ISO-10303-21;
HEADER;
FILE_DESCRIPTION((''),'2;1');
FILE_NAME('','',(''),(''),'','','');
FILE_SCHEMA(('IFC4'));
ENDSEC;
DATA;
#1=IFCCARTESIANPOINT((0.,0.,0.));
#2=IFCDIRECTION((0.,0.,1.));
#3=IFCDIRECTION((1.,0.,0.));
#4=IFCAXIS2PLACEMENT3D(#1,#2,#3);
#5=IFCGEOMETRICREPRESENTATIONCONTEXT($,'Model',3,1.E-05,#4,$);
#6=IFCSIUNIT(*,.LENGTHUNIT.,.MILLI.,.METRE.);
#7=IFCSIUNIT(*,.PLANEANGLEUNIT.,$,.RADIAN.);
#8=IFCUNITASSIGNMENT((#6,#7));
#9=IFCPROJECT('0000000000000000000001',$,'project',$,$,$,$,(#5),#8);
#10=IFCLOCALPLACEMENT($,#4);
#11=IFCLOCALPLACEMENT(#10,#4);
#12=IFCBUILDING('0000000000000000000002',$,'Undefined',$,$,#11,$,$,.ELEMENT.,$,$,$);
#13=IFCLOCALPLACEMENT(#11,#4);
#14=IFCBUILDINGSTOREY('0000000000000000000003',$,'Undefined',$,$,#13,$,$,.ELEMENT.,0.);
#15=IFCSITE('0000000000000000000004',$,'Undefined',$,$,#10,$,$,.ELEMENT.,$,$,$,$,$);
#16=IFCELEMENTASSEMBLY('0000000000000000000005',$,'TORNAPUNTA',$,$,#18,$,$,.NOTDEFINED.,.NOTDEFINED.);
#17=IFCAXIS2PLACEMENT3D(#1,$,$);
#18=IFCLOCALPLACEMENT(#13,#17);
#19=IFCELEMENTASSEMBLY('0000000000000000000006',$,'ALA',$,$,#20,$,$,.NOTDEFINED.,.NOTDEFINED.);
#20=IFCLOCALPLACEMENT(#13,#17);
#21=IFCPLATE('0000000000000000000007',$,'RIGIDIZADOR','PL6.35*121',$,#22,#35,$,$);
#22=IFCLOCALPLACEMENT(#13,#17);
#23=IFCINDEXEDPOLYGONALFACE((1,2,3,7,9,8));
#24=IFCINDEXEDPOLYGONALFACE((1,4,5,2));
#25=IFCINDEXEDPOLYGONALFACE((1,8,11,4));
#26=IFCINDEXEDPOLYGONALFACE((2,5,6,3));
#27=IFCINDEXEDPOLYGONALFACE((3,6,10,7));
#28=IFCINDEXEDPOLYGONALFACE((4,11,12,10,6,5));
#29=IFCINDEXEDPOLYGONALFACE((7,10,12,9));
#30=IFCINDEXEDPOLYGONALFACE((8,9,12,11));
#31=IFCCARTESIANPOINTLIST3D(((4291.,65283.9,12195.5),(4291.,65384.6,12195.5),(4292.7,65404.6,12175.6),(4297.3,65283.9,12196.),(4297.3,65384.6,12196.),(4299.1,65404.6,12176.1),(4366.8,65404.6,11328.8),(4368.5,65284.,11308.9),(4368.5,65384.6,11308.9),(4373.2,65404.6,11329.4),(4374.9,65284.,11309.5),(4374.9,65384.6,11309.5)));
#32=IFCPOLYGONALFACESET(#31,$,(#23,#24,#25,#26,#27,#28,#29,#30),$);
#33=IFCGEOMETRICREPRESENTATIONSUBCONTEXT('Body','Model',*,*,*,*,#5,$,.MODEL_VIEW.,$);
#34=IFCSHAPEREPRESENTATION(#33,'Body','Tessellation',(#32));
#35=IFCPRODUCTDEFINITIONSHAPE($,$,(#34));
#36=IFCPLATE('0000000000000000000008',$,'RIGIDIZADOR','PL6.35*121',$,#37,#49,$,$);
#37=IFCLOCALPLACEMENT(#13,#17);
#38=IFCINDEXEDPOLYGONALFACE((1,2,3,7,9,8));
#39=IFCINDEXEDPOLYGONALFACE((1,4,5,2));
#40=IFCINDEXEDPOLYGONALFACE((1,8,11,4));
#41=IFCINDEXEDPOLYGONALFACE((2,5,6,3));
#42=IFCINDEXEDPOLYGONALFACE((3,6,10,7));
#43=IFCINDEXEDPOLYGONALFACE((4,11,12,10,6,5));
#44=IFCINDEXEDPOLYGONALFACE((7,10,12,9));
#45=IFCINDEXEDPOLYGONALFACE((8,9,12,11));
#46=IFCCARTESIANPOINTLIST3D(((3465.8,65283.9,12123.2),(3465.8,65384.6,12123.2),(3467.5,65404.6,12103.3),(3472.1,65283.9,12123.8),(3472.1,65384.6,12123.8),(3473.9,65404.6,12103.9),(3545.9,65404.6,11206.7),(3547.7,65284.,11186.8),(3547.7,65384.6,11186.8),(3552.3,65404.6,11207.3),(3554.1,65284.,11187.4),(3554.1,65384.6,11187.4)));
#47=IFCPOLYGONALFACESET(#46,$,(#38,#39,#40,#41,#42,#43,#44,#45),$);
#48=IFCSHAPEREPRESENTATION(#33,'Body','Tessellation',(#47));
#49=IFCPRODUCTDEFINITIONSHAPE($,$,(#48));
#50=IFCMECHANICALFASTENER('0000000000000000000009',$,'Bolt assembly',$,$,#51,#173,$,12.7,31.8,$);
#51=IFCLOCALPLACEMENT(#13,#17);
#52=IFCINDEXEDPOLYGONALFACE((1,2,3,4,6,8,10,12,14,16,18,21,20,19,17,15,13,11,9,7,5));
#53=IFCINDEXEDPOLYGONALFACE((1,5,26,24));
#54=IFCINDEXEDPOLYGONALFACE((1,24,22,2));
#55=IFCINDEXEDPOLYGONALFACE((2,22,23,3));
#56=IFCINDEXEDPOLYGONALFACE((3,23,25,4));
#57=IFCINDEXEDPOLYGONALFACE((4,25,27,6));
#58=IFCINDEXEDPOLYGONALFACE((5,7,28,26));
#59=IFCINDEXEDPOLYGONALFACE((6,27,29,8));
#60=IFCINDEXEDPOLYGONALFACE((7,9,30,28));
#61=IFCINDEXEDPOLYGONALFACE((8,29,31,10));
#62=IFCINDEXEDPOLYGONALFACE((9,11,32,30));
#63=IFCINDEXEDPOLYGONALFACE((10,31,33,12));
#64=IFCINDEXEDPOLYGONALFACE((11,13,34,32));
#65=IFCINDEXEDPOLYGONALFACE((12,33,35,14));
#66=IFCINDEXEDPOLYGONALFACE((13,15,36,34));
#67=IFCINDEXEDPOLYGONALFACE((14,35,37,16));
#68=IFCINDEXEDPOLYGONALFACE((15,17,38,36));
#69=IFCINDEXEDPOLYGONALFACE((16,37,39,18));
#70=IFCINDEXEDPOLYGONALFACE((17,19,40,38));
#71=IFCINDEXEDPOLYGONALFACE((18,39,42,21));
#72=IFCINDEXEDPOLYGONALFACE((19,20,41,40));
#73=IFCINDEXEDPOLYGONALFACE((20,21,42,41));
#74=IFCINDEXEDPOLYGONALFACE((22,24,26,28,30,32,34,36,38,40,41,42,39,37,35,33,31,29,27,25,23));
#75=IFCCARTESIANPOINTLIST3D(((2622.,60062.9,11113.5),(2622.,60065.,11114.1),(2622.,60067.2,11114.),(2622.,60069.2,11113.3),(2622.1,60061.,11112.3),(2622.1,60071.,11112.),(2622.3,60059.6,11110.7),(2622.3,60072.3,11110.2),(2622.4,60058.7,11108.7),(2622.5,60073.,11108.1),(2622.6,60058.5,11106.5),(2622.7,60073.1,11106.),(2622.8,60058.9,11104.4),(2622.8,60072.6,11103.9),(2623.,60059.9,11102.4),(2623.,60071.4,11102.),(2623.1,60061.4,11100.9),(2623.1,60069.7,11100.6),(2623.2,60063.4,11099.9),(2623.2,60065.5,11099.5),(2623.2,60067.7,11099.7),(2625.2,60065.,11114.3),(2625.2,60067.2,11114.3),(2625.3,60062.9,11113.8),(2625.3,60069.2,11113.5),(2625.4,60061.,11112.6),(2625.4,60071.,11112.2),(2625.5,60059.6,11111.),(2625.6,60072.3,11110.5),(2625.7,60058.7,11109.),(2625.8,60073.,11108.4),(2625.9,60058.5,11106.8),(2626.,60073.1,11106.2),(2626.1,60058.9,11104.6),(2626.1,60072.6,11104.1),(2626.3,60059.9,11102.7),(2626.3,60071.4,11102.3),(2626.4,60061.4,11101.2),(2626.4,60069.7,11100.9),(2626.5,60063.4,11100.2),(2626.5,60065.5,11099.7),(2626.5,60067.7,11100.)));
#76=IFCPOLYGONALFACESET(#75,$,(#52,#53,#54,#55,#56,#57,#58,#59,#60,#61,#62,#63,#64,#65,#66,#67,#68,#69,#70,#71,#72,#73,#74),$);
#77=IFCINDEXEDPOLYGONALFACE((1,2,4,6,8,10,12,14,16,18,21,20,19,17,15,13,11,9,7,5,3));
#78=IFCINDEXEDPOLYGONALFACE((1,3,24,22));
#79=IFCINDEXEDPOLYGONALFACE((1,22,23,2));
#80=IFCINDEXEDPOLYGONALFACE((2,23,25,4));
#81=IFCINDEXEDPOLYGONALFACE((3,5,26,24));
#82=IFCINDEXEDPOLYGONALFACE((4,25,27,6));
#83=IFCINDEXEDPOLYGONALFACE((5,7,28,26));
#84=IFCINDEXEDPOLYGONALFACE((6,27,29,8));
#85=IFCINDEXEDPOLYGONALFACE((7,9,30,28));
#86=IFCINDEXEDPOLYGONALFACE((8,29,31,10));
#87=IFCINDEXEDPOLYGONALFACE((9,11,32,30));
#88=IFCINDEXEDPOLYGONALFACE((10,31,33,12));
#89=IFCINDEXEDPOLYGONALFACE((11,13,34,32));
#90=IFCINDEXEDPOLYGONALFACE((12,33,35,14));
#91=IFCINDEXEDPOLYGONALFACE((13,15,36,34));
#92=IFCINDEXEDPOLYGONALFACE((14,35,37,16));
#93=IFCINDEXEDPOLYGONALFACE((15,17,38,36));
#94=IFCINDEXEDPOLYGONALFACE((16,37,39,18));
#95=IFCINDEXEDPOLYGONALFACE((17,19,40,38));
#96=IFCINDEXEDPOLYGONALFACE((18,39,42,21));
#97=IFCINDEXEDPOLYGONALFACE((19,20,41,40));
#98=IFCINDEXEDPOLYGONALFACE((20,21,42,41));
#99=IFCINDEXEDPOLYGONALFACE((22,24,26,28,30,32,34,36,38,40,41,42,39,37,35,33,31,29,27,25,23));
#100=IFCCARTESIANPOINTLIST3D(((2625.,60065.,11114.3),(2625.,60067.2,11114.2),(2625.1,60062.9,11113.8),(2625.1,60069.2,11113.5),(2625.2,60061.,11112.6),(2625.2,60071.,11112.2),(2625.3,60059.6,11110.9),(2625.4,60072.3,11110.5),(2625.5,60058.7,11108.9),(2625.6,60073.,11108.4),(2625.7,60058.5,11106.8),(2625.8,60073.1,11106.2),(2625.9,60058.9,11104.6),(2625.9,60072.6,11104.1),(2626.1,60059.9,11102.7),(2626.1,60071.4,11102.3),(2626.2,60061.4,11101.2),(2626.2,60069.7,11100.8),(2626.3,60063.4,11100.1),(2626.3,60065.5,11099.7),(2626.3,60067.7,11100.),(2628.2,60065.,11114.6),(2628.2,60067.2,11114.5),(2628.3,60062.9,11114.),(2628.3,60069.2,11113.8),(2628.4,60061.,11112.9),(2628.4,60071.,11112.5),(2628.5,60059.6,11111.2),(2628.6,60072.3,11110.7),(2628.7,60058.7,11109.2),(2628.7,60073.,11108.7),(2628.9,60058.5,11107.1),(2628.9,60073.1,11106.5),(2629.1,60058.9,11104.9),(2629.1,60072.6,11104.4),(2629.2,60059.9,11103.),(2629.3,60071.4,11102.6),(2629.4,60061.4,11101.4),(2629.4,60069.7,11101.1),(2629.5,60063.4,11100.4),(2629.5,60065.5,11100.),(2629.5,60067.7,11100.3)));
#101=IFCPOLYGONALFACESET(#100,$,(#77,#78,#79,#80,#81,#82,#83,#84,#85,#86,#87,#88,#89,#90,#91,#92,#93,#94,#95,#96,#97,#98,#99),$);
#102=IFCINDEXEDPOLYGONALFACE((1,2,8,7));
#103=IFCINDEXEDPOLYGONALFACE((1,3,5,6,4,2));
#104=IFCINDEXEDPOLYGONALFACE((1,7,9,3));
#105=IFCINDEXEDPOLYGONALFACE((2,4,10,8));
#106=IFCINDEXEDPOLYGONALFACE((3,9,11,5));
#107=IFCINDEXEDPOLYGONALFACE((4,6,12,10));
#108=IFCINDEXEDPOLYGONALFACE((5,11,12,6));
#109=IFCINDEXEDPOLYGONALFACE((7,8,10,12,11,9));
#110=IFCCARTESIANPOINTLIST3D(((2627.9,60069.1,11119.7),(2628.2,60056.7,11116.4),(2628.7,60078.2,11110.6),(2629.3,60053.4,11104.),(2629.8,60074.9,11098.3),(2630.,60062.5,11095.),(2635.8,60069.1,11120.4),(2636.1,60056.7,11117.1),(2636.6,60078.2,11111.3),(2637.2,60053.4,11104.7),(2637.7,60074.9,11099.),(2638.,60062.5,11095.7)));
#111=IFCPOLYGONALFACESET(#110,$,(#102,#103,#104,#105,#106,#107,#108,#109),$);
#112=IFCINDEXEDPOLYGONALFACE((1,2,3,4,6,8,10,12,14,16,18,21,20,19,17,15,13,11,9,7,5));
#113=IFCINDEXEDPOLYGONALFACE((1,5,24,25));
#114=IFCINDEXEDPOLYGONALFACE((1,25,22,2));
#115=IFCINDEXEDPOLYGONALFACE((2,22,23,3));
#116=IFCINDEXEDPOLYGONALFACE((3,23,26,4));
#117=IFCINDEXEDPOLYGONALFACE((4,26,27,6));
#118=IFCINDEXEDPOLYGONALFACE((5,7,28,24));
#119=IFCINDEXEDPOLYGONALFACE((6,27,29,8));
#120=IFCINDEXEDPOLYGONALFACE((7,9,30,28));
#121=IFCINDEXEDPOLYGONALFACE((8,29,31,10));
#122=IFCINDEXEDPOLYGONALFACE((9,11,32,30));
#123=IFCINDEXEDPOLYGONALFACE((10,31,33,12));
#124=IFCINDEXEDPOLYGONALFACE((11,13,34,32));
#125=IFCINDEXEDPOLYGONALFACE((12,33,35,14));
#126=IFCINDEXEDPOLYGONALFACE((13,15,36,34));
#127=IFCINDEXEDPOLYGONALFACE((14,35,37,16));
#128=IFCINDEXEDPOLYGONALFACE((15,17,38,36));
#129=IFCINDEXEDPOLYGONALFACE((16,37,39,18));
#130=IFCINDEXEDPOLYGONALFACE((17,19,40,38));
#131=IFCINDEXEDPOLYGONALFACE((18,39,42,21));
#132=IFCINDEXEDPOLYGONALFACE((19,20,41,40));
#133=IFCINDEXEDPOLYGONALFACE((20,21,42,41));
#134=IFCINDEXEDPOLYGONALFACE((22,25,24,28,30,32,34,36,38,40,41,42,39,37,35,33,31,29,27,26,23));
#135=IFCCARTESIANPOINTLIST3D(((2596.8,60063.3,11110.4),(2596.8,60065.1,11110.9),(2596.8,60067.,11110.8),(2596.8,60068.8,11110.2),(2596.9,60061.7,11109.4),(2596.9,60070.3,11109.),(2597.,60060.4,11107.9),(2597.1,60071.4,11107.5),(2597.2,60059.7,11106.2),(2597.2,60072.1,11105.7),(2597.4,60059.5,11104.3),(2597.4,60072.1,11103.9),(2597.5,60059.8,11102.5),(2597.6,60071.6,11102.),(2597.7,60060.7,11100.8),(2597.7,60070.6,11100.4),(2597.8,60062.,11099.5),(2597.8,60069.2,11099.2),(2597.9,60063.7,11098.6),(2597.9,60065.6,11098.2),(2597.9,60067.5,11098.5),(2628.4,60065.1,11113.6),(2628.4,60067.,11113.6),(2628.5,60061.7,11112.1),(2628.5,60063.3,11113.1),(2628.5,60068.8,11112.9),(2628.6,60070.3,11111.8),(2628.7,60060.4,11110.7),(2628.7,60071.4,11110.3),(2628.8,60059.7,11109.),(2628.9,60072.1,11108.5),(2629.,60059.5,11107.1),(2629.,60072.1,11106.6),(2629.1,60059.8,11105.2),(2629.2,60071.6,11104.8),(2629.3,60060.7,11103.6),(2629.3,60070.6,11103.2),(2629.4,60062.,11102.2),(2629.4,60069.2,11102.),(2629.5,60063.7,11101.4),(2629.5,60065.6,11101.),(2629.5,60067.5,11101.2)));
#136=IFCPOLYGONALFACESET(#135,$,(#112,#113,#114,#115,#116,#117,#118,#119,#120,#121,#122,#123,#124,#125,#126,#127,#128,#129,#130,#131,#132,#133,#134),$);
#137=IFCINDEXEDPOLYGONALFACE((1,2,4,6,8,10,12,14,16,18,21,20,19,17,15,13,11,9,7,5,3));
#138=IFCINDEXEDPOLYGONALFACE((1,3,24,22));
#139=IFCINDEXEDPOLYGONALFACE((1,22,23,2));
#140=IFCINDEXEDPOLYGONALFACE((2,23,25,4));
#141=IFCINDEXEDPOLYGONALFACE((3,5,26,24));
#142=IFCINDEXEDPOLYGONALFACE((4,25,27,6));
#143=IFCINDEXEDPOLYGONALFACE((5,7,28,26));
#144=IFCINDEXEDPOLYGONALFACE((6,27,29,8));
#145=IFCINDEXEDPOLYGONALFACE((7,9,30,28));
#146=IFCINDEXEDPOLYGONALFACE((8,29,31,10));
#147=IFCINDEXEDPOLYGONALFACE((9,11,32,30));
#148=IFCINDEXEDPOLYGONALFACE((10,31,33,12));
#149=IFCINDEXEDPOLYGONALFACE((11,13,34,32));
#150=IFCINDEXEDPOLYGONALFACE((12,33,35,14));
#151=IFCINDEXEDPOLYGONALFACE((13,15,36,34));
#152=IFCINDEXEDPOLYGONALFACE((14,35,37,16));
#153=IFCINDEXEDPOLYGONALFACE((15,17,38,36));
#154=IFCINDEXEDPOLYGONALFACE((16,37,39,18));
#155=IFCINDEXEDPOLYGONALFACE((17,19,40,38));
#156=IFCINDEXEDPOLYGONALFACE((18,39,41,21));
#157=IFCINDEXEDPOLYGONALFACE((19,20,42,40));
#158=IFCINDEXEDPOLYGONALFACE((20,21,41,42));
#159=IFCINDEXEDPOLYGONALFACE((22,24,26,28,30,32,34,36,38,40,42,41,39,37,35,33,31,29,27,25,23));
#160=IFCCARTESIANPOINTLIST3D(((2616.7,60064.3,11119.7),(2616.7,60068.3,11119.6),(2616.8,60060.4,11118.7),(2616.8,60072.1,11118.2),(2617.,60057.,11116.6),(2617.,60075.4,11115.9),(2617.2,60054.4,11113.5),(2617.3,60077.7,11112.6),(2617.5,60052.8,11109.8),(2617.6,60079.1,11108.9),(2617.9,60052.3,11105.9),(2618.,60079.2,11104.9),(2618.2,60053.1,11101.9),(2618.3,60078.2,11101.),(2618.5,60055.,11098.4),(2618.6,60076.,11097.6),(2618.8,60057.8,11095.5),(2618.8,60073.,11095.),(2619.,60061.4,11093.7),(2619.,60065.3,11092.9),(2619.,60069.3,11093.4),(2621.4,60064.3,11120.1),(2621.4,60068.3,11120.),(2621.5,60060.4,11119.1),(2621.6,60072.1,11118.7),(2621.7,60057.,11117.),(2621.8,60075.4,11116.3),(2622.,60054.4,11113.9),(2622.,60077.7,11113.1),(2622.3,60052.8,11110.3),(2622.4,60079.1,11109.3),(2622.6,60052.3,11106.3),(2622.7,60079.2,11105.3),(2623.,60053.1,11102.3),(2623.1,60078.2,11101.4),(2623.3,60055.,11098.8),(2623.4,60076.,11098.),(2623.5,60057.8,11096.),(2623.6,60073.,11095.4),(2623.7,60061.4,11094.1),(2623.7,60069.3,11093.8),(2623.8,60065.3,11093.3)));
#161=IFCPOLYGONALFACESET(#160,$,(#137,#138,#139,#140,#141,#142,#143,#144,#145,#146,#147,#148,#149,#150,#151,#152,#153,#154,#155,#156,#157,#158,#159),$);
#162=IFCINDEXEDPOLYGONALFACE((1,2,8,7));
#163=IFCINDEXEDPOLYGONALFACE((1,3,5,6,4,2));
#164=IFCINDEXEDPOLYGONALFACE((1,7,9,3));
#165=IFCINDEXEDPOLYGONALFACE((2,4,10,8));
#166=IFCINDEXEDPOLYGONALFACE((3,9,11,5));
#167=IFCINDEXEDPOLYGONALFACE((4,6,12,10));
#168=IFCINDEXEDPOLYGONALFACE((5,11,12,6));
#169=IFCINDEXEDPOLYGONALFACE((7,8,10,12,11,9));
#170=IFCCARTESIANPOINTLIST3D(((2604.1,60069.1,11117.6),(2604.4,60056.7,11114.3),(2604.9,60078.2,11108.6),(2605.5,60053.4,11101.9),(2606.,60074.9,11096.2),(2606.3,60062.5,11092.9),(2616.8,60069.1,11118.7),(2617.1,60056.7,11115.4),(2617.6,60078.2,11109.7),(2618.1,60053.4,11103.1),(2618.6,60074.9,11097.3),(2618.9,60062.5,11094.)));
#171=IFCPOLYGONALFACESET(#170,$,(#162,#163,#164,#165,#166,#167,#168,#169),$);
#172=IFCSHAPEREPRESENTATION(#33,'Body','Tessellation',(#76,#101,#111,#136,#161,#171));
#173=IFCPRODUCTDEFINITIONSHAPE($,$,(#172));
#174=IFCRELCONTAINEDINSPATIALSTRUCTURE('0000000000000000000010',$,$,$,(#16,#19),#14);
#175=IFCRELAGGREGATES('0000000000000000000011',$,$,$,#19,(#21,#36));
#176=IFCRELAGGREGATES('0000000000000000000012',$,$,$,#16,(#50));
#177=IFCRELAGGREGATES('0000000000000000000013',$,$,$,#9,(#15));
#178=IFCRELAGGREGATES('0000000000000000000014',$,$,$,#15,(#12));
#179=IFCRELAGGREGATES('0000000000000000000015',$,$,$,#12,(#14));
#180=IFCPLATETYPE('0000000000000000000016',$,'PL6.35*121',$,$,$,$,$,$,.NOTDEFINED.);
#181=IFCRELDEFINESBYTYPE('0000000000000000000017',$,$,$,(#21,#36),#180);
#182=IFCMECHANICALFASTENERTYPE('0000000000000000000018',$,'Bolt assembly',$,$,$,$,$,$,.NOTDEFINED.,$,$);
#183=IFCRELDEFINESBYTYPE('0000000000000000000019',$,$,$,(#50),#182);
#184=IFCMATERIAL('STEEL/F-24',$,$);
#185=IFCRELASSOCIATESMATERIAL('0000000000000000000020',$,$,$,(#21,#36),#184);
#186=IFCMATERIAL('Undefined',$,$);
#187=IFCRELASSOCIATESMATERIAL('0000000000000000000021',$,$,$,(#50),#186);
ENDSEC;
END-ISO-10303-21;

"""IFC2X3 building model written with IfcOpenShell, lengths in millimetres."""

from ifc_helpers import new_model, si_unit, frame, origin_with_axes, origin_2d_with_axis, place, context, subcontext, project, spatial, polyline, circle, outline, extrude, source, transform, mapped, material, type_object, element, aggregate, save


model = new_model("IFC2X3")

# Units and contexts
model_context = context("Model", 3, precision=1e-05, world=origin_with_axes())
body_context = subcontext(model_context, "Body", "Model", "MODEL_VIEW")
ifc_project = project(units=[si_unit("LENGTHUNIT", "METRE", prefix="MILLI"), si_unit("PLANEANGLEUNIT", "RADIAN")], contexts=[model_context])

# Site, building, storey
site_placement = place(None, origin_with_axes())
site = spatial("IfcSite", under=ifc_project, at=site_placement, Name="Undefined", CompositionType="ELEMENT")
building_placement = place(site_placement, origin_with_axes())
building = spatial("IfcBuilding", under=site, at=building_placement, Name="Undefined", CompositionType="ELEMENT")
storey_placement = place(building_placement, origin_with_axes())
storey = spatial("IfcBuildingStorey", under=building, at=storey_placement, Name="Undefined", CompositionType="ELEMENT", Elevation=0.0)

# Element assemblies
assembly_1_placement = place(storey_placement, origin_with_axes())
assembly_1 = element("IfcElementAssembly", 1, at=assembly_1_placement, inside=storey, Name="TORNAPUNTA", AssemblyPlace="NOTDEFINED", PredefinedType="NOTDEFINED")
ifc_material_1 = material(Name="STEEL/F-24")
assembly_2_placement = place(storey_placement, origin_with_axes())
assembly_2 = element("IfcElementAssembly", 2, at=assembly_2_placement, inside=storey, Name="ALA", AssemblyPlace="NOTDEFINED", PredefinedType="NOTDEFINED")

# Plates
plate_type_1 = type_object("IfcPlateType", Name="PL6.35*121", PredefinedType="NOTDEFINED")
plate_1_placement = place(assembly_2_placement, frame((4294.1, 65404.6, 12195.8), z_axis=(0.996192, 0.0, 0.087188), x_axis=(0.0, -1.0, 0.0)))
plate_1 = element("IfcPlate", 3, at=plate_1_placement, type_object=plate_type_1, material=ifc_material_1, Name="RIGIDIZADOR", Description="PL6.35*121", context=body_context, shape_type="SweptSolid", body=[
    extrude(outline(polyline([(0.0, 20.0), (20.0, 0.0), (120.6, 0.0), (120.6, 890.0), (20.0, 890.0), (0.0, 870.0), (0.0, 20.0)])), frame((0.0, 0.0, -3.2), z_axis=(0.0, 0.0, 1.0), x_axis=(1.0, 0.0, 0.0)), (0.0, 0.0, 1.0), 6.4),
])
plate_2_placement = place(assembly_2_placement, frame((3468.9, 65404.6, 12123.5), z_axis=(0.996195, 0.0, 0.087155), x_axis=(0.0, -1.0, 0.0)))
plate_2 = element("IfcPlate", 4, at=plate_2_placement, type_object=plate_type_1, material=ifc_material_1, Name="RIGIDIZADOR", Description="PL6.35*121", context=body_context, shape_type="SweptSolid", body=[
    extrude(outline(polyline([(0.0, 20.0), (20.0, 0.0), (120.6, 0.0), (120.6, 940.0), (20.0, 940.0), (0.0, 920.0), (0.0, 20.0)])), frame((0.0, 0.0, -3.2), z_axis=(0.0, 0.0, 1.0), x_axis=(1.0, 0.0, 0.0)), (0.0, 0.0, 1.0), 6.4),
])
aggregate(assembly_2, [plate_1, plate_2])

# Mechanical fastener
ifc_material_2 = material(Name="Undefined")
mechanical_fastener_type = type_object("IfcMechanicalFastenerType", Name="Bolt assembly")
shared_shape_1 = source(origin_with_axes(), body_context, "Body", "SweptSolid", [
    extrude(circle(Radius=7.3, at=origin_2d_with_axis()), frame((0.0, -0.1, 0.0), z_axis=(0.0, 1.0, 0.0), x_axis=(1.0, 0.0, 0.0)), (0.0, 0.0, 1.0), 3.3),
    extrude(circle(Radius=7.3, at=origin_2d_with_axis()), frame((0.0, -3.1, 0.0), z_axis=(0.0, 1.0, 0.0), x_axis=(1.0, 0.0, 0.0)), (0.0, 0.0, 1.0), 3.2),
    extrude(outline(polyline([(11.1, -6.4), (11.1, 6.4), (0.0, 12.8), (-11.1, 6.4), (-11.1, -6.4), (0.0, -12.8), (11.1, -6.4)])), frame((0.0, -11.1, 0.0), z_axis=(0.0, 1.0, 0.0), x_axis=(1.0, 0.0, 0.0)), (0.0, 0.0, 1.0), 7.9),
    extrude(circle(Radius=6.3, at=origin_2d_with_axis()), frame((0.0, -3.2, 0.0), z_axis=(0.0, 1.0, 0.0), x_axis=(1.0, 0.0, 0.0)), (0.0, 0.0, 1.0), 31.8),
    extrude(circle(Radius=13.5, at=origin_2d_with_axis()), frame((0.0, 3.2, 0.0), z_axis=(0.0, 1.0, 0.0), x_axis=(1.0, 0.0, 0.0)), (0.0, 0.0, 1.0), 4.8),
    extrude(outline(polyline([(11.1, -6.4), (11.1, 6.4), (0.0, 12.8), (-11.1, 6.4), (-11.1, -6.4), (0.0, -12.8), (11.1, -6.4)])), frame((0.0, 8.0, 0.0), z_axis=(0.0, 1.0, 0.0), x_axis=(1.0, 0.0, 0.0)), (0.0, 0.0, 1.0), 12.7),
])
mechanical_fastener_1_placement = place(assembly_1_placement, frame((2625.8, 60065.8, 11107.1), z_axis=(-0.061628, -0.707107, 0.704416), x_axis=(-0.061628, 0.707107, 0.704416)))
mechanical_fastener_1 = element("IfcMechanicalFastener", 5, at=mechanical_fastener_1_placement, type_object=mechanical_fastener_type, material=ifc_material_2, Name="Bolt assembly", NominalDiameter=12.7, NominalLength=31.8, context=body_context, shape_type="MappedRepresentation", body=[
    mapped(shared_shape_1, transform((0.0, 0.0, 0.0))),
])
aggregate(assembly_1, [mechanical_fastener_1])

save(model, "model.ifc")
